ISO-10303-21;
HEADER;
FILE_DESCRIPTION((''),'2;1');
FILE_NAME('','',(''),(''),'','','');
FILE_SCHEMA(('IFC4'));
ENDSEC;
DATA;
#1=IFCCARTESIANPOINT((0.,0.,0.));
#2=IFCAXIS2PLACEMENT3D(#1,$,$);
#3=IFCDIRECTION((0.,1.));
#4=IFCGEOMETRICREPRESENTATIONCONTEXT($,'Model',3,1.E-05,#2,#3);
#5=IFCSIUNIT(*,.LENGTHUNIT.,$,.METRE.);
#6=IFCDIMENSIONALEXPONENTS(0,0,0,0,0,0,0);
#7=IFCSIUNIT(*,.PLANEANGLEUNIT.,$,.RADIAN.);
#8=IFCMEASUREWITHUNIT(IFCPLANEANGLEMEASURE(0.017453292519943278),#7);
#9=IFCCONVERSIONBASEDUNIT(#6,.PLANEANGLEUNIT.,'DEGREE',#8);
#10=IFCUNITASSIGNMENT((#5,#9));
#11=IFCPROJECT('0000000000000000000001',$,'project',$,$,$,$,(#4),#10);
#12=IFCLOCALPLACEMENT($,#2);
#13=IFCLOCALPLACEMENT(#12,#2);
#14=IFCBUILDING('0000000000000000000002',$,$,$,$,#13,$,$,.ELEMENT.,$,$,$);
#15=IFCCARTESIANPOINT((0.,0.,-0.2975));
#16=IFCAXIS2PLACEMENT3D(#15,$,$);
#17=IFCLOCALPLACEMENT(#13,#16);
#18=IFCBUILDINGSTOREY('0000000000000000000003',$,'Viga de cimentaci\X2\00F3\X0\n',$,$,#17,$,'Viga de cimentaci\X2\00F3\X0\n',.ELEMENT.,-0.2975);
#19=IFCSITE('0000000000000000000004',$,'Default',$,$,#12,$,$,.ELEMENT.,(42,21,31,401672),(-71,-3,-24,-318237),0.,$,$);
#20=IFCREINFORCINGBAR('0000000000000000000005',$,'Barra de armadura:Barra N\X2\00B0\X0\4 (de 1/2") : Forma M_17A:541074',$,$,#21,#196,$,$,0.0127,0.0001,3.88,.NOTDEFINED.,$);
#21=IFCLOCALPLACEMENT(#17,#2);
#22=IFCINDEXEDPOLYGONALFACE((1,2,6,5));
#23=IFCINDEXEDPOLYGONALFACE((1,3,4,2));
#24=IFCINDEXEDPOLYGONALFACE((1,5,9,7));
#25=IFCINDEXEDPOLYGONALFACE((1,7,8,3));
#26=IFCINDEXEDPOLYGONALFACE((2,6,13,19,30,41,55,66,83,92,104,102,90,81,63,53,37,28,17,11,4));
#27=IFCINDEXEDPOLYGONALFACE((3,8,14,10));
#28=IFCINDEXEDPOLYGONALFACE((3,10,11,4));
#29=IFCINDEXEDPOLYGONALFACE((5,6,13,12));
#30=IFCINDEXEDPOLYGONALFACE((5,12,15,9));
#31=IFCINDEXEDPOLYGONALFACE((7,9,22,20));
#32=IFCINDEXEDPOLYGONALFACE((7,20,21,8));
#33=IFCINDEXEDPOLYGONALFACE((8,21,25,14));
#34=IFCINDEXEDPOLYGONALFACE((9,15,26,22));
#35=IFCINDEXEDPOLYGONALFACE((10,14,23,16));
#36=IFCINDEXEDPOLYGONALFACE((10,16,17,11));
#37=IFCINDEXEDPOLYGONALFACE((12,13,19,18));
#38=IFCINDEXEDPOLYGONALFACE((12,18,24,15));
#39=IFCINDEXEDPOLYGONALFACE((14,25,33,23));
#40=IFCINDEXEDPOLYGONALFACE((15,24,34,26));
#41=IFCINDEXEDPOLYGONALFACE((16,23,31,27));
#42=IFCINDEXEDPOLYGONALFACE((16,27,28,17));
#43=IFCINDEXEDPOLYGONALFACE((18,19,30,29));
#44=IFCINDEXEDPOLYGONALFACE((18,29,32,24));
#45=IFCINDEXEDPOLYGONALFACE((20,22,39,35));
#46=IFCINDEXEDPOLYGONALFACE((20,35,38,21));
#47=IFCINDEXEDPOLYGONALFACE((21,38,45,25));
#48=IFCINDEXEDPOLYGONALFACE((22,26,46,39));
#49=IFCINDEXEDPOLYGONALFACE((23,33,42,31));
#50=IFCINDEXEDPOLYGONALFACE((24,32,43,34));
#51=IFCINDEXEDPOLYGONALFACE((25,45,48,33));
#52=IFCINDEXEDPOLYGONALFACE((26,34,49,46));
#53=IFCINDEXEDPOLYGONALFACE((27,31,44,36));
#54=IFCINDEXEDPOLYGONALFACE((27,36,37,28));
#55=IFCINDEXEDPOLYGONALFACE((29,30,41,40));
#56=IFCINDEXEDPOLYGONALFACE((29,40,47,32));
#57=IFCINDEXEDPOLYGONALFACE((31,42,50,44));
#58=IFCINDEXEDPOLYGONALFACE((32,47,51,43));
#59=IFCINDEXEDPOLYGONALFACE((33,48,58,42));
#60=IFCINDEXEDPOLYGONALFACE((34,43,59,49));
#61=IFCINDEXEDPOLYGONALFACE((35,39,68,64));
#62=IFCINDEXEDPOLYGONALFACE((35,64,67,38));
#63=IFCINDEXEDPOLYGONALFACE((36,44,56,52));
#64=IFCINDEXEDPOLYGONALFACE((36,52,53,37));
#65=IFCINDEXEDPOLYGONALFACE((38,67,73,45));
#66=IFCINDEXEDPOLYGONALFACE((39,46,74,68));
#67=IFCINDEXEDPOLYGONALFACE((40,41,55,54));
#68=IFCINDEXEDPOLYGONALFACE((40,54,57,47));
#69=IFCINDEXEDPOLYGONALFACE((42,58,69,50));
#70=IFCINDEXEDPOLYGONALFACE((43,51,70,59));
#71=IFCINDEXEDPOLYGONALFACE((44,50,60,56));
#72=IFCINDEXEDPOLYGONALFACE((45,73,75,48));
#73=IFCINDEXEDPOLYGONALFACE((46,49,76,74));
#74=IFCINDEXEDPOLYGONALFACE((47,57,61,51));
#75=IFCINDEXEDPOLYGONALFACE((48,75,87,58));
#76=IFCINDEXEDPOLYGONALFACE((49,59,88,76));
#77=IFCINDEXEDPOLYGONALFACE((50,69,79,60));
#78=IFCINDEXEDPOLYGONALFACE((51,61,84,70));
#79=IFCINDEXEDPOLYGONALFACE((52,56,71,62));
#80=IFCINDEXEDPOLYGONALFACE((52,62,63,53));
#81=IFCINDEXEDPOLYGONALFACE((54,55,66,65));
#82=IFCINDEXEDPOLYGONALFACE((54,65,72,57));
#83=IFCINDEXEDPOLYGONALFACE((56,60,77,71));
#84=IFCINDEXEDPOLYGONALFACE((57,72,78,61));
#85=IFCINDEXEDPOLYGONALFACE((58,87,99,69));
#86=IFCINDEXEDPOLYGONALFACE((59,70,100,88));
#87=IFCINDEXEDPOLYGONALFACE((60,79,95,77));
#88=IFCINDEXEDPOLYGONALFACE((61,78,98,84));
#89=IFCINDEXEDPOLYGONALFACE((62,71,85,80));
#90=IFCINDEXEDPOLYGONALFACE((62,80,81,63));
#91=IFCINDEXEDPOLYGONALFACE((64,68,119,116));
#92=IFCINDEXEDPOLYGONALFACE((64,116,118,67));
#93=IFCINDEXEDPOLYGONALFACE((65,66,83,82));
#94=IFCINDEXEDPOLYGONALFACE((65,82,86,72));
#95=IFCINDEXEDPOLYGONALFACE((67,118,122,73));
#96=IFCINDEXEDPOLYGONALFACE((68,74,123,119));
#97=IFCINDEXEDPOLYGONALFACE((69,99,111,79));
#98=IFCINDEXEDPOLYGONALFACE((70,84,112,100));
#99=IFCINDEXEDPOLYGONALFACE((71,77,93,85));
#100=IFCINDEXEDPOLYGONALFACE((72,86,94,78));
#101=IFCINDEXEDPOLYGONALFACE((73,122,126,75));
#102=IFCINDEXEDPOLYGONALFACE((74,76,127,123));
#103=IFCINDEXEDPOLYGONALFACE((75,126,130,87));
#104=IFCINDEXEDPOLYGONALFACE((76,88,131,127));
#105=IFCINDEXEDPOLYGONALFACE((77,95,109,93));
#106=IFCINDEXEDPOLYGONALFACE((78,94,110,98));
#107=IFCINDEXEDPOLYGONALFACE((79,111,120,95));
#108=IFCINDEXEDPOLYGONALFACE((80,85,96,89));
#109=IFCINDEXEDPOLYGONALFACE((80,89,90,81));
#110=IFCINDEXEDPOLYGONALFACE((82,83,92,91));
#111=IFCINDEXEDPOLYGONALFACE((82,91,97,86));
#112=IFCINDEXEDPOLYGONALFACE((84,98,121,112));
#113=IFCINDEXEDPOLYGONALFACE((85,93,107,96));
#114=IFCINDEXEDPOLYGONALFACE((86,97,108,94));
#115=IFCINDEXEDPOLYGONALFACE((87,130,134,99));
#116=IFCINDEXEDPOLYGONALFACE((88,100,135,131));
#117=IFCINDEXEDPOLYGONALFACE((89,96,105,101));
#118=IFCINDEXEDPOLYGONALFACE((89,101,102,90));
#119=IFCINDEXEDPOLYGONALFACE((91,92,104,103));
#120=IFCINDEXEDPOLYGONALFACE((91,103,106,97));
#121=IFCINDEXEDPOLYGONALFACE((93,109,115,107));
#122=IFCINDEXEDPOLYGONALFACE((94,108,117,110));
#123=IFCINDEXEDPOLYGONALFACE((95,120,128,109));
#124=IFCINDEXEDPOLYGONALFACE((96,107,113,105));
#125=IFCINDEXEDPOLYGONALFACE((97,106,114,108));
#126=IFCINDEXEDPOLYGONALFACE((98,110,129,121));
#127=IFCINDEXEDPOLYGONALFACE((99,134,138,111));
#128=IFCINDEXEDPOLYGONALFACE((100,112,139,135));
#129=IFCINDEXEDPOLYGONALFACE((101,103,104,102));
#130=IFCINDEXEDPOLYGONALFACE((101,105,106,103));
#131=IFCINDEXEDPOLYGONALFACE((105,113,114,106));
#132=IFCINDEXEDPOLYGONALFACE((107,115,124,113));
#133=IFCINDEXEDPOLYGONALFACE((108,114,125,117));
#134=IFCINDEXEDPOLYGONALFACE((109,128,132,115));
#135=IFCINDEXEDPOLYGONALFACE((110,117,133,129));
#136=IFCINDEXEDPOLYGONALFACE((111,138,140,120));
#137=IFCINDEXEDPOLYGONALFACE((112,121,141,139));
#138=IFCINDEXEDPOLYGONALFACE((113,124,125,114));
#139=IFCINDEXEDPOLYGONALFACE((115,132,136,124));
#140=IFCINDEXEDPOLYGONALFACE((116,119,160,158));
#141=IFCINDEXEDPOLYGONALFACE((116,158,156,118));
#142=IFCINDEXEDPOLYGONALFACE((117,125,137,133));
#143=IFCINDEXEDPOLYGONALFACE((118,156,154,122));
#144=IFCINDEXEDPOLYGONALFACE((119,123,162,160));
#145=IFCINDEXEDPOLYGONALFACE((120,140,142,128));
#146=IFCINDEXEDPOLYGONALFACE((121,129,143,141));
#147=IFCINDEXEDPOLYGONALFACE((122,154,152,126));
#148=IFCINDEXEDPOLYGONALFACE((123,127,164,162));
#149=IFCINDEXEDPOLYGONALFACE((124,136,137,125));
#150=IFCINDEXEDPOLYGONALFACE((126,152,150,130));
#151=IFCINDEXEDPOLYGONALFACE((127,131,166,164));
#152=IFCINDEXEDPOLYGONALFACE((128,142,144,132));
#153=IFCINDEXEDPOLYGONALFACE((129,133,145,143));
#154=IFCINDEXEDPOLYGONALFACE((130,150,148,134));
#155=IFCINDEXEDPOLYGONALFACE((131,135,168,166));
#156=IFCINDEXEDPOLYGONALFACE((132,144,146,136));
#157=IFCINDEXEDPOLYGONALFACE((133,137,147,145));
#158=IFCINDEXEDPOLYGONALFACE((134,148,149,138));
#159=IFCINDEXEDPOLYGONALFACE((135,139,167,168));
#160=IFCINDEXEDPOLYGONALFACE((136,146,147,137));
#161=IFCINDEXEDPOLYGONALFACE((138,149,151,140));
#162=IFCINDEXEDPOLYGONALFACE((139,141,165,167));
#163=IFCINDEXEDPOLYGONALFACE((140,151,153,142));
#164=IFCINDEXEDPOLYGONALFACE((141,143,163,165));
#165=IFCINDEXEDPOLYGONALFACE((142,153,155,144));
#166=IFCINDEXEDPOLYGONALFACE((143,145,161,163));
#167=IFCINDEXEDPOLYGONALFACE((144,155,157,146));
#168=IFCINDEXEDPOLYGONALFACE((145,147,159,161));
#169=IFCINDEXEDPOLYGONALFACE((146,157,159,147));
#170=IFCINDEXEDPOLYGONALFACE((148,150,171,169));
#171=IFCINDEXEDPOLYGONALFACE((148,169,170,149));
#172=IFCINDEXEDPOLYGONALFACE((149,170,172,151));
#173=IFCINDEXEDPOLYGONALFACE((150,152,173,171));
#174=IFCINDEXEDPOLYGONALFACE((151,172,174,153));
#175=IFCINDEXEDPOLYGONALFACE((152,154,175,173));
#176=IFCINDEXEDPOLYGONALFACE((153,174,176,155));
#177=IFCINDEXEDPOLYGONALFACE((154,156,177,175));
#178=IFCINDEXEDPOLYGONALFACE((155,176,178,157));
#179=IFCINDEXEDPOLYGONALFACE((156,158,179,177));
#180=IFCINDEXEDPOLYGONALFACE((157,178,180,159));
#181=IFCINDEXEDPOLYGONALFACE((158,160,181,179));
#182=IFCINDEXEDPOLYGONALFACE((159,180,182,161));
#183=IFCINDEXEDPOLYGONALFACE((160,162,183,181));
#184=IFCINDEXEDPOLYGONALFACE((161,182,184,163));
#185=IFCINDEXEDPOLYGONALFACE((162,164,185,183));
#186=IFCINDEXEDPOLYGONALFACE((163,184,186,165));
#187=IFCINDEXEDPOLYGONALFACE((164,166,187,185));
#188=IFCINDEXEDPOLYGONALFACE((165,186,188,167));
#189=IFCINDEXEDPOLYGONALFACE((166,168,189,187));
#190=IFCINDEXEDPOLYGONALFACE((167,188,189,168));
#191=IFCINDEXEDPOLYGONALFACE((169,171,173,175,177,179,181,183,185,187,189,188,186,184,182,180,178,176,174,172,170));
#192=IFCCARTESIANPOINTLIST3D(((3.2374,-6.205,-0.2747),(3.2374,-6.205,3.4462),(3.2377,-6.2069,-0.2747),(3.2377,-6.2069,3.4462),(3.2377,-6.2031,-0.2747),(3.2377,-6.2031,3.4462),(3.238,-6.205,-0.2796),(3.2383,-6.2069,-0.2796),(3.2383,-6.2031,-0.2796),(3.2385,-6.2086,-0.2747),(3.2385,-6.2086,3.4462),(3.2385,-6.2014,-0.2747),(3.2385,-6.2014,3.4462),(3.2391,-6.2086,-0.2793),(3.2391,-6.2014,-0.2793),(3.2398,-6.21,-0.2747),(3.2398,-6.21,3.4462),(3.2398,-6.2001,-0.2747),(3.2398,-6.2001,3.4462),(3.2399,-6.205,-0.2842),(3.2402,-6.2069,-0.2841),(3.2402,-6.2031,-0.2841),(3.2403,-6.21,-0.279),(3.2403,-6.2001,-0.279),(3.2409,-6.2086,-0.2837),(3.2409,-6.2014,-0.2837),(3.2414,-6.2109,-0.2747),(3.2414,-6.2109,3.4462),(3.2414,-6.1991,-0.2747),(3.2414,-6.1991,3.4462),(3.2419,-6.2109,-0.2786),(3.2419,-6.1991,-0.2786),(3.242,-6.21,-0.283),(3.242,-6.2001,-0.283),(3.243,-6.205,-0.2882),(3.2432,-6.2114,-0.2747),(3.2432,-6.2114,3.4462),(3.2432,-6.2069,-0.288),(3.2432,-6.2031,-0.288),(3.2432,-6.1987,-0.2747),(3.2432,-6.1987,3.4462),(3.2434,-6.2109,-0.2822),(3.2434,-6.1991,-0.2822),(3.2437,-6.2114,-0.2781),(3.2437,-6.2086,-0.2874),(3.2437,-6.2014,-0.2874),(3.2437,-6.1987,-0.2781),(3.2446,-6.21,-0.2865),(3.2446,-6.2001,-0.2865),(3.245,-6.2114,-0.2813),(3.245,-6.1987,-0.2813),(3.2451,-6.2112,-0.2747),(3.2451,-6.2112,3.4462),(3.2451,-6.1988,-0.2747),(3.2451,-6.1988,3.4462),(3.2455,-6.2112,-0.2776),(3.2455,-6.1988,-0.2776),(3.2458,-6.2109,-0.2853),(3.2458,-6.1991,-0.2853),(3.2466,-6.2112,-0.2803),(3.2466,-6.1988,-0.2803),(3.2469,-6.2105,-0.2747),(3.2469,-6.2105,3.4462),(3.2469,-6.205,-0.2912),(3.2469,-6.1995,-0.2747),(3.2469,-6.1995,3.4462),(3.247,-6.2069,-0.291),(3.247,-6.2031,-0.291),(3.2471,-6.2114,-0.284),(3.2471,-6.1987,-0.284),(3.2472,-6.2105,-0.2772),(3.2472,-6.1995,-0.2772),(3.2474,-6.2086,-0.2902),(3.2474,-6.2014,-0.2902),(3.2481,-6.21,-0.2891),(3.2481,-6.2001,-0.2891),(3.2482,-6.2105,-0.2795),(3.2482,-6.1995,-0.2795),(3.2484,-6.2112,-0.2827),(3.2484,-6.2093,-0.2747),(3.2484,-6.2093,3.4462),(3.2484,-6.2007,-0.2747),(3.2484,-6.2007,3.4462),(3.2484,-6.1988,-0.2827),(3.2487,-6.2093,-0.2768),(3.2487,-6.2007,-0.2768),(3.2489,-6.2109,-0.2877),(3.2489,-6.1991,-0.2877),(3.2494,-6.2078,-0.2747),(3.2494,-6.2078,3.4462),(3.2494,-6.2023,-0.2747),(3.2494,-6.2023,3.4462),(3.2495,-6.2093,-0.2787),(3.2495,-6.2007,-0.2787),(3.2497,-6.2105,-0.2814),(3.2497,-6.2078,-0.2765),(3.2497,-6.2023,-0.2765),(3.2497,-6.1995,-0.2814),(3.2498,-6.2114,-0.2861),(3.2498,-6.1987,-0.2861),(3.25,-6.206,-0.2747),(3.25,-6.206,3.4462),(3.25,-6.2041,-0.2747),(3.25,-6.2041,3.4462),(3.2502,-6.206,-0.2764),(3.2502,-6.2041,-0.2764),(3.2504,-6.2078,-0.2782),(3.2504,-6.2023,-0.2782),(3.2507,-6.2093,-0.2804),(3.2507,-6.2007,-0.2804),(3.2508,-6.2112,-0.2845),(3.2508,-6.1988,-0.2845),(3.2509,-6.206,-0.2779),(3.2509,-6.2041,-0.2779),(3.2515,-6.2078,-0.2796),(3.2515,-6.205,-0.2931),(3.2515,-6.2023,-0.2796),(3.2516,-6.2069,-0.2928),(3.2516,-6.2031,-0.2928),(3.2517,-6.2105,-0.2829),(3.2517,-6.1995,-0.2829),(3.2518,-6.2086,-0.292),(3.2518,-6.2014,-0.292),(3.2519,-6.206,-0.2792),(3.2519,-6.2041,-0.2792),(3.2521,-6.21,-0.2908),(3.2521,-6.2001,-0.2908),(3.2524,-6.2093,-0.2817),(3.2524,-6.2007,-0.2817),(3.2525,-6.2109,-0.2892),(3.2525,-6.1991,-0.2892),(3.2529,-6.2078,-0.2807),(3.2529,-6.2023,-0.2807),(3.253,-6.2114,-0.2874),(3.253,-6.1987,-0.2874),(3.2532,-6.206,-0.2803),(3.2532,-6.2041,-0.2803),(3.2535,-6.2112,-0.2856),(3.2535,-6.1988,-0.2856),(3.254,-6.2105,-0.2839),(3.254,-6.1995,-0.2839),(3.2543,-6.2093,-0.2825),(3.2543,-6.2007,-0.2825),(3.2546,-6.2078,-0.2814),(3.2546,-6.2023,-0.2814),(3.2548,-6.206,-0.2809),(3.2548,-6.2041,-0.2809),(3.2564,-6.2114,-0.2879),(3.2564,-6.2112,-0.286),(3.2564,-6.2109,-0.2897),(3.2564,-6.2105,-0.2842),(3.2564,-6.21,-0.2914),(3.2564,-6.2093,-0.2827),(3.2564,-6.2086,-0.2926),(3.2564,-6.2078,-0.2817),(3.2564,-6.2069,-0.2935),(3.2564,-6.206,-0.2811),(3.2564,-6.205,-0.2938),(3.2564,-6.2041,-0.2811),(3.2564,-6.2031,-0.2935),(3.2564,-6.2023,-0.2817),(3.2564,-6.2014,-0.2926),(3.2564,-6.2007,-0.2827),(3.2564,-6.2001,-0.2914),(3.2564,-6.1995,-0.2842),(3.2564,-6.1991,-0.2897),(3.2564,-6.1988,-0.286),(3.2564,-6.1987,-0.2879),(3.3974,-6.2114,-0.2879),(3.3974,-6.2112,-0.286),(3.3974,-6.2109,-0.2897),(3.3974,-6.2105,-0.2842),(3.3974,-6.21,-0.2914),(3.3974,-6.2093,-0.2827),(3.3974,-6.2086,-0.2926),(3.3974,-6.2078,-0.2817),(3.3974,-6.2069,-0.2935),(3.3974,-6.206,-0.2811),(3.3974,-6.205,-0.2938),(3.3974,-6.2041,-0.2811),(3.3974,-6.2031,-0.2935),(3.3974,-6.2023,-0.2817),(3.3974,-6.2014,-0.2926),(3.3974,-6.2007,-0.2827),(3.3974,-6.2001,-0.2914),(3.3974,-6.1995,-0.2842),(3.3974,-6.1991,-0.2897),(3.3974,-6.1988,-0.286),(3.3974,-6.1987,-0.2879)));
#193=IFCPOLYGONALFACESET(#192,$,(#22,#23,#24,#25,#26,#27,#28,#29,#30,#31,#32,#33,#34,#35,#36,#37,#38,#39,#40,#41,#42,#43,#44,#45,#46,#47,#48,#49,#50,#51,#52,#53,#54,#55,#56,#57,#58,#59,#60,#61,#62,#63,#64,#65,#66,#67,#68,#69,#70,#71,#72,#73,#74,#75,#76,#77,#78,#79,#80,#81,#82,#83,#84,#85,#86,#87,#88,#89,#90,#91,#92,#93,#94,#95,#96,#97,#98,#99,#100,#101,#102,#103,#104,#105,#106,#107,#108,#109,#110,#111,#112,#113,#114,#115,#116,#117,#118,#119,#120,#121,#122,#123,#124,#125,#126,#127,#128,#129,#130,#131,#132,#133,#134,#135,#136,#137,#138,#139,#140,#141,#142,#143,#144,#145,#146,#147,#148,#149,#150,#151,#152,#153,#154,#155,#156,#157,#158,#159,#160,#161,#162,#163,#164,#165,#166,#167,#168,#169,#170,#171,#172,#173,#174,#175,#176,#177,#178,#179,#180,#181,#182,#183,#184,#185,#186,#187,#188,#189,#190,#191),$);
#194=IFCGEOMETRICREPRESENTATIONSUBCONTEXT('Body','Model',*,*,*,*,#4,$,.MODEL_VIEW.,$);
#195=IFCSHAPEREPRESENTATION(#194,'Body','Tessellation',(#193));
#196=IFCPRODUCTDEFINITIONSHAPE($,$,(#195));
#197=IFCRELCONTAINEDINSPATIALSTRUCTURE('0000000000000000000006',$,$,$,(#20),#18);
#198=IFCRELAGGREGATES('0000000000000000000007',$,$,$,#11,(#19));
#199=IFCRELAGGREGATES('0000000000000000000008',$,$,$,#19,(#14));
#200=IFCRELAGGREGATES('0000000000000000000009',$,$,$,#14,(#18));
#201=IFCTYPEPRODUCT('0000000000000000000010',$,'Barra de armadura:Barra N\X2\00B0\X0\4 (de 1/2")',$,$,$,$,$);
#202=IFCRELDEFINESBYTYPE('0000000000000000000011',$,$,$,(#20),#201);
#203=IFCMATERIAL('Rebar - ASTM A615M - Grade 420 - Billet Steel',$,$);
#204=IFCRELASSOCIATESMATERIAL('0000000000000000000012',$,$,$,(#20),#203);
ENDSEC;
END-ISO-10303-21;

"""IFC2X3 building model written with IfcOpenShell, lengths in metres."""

from ifc_helpers import new_model, entity, si_unit, converted_unit, direction, frame, origin, place, context, subcontext, project, spatial, material, type_object, element, save


model = new_model("IFC2X3")

# Units and contexts
model_context = context("Model", 3, precision=1e-05, world=origin(), true_north=direction((0.0, 1.0)))
body_context = subcontext(model_context, "Body", "Model", "MODEL_VIEW")
ifc_project = project(units=[si_unit("LENGTHUNIT", "METRE"), converted_unit("PLANEANGLEUNIT", "DEGREE", entity("IfcPlaneAngleMeasure", 0.017453292519943278), si_unit("PLANEANGLEUNIT", "RADIAN"), dimensions=[0, 0, 0, 0, 0, 0, 0])], contexts=[model_context])

# Site, building, storey
site_placement = place(None, origin())
site = spatial("IfcSite", under=ifc_project, at=site_placement, Name="Default", CompositionType="ELEMENT", RefLatitude=(42, 21, 31, 401672), RefLongitude=(-71, -3, -24, -318237), RefElevation=0.0)
building_placement = place(site_placement, origin())
building = spatial("IfcBuilding", under=site, at=building_placement, CompositionType="ELEMENT")
storey_placement = place(building_placement, frame((0.0, 0.0, -0.2975)))
storey = spatial("IfcBuildingStorey", under=building, at=storey_placement, Name="Viga de cimentación", LongName="Viga de cimentación", CompositionType="ELEMENT", Elevation=-0.2975)

# Reinforcing bar
ifc_material_1 = material(Name="Rebar - ASTM A615M - Grade 420 - Billet Steel")
type_product_1 = type_object("IfcTypeProduct", Name="Barra de armadura:Barra N°4 (de 1/2\")")
reinforcing_bar_1_placement = place(storey_placement, origin())
element("IfcReinforcingBar", 1, at=reinforcing_bar_1_placement, inside=storey, type_object=type_product_1, material=ifc_material_1, Name="Barra de armadura:Barra N°4 (de 1/2\") : Forma M_17A:541074", BarLength=3.88, BarRole="NOTDEFINED", CrossSectionArea=0.0001, NominalDiameter=0.0127, context=body_context, shape_type="AdvancedSweptSolid", body=[
    entity("IfcSweptDiskSolid", entity("IfcCompositeCurve", [entity("IfcCompositeCurveSegment", "CONTINUOUS", True, entity("IfcPolyline", [entity("IfcCartesianPoint", [3.2437, -6.205, 3.4462]), entity("IfcCartesianPoint", [3.2437, -6.205, -0.2747])])), entity("IfcCompositeCurveSegment", "CONTINUOUS", True, entity("IfcTrimmedCurve", entity("IfcCircle", entity("IfcAxis2Placement3D", entity("IfcCartesianPoint", [3.2564, -6.205, -0.2747]), entity("IfcDirection", [0.0, -1.0, 0.0]), entity("IfcDirection", [0.0, 0.0, -1.0])), 0.0127), [entity("IfcParameterValue", 270.0)], [entity("IfcParameterValue", 360.0)], True, "PARAMETER")), entity("IfcCompositeCurveSegment", "CONTINUOUS", True, entity("IfcPolyline", [entity("IfcCartesianPoint", [3.2564, -6.205, -0.2874]), entity("IfcCartesianPoint", [3.3974, -6.205, -0.2874])]))], False), 0.0063, None, 0.0, 92.0),
])

save(model, "model.ifc")
